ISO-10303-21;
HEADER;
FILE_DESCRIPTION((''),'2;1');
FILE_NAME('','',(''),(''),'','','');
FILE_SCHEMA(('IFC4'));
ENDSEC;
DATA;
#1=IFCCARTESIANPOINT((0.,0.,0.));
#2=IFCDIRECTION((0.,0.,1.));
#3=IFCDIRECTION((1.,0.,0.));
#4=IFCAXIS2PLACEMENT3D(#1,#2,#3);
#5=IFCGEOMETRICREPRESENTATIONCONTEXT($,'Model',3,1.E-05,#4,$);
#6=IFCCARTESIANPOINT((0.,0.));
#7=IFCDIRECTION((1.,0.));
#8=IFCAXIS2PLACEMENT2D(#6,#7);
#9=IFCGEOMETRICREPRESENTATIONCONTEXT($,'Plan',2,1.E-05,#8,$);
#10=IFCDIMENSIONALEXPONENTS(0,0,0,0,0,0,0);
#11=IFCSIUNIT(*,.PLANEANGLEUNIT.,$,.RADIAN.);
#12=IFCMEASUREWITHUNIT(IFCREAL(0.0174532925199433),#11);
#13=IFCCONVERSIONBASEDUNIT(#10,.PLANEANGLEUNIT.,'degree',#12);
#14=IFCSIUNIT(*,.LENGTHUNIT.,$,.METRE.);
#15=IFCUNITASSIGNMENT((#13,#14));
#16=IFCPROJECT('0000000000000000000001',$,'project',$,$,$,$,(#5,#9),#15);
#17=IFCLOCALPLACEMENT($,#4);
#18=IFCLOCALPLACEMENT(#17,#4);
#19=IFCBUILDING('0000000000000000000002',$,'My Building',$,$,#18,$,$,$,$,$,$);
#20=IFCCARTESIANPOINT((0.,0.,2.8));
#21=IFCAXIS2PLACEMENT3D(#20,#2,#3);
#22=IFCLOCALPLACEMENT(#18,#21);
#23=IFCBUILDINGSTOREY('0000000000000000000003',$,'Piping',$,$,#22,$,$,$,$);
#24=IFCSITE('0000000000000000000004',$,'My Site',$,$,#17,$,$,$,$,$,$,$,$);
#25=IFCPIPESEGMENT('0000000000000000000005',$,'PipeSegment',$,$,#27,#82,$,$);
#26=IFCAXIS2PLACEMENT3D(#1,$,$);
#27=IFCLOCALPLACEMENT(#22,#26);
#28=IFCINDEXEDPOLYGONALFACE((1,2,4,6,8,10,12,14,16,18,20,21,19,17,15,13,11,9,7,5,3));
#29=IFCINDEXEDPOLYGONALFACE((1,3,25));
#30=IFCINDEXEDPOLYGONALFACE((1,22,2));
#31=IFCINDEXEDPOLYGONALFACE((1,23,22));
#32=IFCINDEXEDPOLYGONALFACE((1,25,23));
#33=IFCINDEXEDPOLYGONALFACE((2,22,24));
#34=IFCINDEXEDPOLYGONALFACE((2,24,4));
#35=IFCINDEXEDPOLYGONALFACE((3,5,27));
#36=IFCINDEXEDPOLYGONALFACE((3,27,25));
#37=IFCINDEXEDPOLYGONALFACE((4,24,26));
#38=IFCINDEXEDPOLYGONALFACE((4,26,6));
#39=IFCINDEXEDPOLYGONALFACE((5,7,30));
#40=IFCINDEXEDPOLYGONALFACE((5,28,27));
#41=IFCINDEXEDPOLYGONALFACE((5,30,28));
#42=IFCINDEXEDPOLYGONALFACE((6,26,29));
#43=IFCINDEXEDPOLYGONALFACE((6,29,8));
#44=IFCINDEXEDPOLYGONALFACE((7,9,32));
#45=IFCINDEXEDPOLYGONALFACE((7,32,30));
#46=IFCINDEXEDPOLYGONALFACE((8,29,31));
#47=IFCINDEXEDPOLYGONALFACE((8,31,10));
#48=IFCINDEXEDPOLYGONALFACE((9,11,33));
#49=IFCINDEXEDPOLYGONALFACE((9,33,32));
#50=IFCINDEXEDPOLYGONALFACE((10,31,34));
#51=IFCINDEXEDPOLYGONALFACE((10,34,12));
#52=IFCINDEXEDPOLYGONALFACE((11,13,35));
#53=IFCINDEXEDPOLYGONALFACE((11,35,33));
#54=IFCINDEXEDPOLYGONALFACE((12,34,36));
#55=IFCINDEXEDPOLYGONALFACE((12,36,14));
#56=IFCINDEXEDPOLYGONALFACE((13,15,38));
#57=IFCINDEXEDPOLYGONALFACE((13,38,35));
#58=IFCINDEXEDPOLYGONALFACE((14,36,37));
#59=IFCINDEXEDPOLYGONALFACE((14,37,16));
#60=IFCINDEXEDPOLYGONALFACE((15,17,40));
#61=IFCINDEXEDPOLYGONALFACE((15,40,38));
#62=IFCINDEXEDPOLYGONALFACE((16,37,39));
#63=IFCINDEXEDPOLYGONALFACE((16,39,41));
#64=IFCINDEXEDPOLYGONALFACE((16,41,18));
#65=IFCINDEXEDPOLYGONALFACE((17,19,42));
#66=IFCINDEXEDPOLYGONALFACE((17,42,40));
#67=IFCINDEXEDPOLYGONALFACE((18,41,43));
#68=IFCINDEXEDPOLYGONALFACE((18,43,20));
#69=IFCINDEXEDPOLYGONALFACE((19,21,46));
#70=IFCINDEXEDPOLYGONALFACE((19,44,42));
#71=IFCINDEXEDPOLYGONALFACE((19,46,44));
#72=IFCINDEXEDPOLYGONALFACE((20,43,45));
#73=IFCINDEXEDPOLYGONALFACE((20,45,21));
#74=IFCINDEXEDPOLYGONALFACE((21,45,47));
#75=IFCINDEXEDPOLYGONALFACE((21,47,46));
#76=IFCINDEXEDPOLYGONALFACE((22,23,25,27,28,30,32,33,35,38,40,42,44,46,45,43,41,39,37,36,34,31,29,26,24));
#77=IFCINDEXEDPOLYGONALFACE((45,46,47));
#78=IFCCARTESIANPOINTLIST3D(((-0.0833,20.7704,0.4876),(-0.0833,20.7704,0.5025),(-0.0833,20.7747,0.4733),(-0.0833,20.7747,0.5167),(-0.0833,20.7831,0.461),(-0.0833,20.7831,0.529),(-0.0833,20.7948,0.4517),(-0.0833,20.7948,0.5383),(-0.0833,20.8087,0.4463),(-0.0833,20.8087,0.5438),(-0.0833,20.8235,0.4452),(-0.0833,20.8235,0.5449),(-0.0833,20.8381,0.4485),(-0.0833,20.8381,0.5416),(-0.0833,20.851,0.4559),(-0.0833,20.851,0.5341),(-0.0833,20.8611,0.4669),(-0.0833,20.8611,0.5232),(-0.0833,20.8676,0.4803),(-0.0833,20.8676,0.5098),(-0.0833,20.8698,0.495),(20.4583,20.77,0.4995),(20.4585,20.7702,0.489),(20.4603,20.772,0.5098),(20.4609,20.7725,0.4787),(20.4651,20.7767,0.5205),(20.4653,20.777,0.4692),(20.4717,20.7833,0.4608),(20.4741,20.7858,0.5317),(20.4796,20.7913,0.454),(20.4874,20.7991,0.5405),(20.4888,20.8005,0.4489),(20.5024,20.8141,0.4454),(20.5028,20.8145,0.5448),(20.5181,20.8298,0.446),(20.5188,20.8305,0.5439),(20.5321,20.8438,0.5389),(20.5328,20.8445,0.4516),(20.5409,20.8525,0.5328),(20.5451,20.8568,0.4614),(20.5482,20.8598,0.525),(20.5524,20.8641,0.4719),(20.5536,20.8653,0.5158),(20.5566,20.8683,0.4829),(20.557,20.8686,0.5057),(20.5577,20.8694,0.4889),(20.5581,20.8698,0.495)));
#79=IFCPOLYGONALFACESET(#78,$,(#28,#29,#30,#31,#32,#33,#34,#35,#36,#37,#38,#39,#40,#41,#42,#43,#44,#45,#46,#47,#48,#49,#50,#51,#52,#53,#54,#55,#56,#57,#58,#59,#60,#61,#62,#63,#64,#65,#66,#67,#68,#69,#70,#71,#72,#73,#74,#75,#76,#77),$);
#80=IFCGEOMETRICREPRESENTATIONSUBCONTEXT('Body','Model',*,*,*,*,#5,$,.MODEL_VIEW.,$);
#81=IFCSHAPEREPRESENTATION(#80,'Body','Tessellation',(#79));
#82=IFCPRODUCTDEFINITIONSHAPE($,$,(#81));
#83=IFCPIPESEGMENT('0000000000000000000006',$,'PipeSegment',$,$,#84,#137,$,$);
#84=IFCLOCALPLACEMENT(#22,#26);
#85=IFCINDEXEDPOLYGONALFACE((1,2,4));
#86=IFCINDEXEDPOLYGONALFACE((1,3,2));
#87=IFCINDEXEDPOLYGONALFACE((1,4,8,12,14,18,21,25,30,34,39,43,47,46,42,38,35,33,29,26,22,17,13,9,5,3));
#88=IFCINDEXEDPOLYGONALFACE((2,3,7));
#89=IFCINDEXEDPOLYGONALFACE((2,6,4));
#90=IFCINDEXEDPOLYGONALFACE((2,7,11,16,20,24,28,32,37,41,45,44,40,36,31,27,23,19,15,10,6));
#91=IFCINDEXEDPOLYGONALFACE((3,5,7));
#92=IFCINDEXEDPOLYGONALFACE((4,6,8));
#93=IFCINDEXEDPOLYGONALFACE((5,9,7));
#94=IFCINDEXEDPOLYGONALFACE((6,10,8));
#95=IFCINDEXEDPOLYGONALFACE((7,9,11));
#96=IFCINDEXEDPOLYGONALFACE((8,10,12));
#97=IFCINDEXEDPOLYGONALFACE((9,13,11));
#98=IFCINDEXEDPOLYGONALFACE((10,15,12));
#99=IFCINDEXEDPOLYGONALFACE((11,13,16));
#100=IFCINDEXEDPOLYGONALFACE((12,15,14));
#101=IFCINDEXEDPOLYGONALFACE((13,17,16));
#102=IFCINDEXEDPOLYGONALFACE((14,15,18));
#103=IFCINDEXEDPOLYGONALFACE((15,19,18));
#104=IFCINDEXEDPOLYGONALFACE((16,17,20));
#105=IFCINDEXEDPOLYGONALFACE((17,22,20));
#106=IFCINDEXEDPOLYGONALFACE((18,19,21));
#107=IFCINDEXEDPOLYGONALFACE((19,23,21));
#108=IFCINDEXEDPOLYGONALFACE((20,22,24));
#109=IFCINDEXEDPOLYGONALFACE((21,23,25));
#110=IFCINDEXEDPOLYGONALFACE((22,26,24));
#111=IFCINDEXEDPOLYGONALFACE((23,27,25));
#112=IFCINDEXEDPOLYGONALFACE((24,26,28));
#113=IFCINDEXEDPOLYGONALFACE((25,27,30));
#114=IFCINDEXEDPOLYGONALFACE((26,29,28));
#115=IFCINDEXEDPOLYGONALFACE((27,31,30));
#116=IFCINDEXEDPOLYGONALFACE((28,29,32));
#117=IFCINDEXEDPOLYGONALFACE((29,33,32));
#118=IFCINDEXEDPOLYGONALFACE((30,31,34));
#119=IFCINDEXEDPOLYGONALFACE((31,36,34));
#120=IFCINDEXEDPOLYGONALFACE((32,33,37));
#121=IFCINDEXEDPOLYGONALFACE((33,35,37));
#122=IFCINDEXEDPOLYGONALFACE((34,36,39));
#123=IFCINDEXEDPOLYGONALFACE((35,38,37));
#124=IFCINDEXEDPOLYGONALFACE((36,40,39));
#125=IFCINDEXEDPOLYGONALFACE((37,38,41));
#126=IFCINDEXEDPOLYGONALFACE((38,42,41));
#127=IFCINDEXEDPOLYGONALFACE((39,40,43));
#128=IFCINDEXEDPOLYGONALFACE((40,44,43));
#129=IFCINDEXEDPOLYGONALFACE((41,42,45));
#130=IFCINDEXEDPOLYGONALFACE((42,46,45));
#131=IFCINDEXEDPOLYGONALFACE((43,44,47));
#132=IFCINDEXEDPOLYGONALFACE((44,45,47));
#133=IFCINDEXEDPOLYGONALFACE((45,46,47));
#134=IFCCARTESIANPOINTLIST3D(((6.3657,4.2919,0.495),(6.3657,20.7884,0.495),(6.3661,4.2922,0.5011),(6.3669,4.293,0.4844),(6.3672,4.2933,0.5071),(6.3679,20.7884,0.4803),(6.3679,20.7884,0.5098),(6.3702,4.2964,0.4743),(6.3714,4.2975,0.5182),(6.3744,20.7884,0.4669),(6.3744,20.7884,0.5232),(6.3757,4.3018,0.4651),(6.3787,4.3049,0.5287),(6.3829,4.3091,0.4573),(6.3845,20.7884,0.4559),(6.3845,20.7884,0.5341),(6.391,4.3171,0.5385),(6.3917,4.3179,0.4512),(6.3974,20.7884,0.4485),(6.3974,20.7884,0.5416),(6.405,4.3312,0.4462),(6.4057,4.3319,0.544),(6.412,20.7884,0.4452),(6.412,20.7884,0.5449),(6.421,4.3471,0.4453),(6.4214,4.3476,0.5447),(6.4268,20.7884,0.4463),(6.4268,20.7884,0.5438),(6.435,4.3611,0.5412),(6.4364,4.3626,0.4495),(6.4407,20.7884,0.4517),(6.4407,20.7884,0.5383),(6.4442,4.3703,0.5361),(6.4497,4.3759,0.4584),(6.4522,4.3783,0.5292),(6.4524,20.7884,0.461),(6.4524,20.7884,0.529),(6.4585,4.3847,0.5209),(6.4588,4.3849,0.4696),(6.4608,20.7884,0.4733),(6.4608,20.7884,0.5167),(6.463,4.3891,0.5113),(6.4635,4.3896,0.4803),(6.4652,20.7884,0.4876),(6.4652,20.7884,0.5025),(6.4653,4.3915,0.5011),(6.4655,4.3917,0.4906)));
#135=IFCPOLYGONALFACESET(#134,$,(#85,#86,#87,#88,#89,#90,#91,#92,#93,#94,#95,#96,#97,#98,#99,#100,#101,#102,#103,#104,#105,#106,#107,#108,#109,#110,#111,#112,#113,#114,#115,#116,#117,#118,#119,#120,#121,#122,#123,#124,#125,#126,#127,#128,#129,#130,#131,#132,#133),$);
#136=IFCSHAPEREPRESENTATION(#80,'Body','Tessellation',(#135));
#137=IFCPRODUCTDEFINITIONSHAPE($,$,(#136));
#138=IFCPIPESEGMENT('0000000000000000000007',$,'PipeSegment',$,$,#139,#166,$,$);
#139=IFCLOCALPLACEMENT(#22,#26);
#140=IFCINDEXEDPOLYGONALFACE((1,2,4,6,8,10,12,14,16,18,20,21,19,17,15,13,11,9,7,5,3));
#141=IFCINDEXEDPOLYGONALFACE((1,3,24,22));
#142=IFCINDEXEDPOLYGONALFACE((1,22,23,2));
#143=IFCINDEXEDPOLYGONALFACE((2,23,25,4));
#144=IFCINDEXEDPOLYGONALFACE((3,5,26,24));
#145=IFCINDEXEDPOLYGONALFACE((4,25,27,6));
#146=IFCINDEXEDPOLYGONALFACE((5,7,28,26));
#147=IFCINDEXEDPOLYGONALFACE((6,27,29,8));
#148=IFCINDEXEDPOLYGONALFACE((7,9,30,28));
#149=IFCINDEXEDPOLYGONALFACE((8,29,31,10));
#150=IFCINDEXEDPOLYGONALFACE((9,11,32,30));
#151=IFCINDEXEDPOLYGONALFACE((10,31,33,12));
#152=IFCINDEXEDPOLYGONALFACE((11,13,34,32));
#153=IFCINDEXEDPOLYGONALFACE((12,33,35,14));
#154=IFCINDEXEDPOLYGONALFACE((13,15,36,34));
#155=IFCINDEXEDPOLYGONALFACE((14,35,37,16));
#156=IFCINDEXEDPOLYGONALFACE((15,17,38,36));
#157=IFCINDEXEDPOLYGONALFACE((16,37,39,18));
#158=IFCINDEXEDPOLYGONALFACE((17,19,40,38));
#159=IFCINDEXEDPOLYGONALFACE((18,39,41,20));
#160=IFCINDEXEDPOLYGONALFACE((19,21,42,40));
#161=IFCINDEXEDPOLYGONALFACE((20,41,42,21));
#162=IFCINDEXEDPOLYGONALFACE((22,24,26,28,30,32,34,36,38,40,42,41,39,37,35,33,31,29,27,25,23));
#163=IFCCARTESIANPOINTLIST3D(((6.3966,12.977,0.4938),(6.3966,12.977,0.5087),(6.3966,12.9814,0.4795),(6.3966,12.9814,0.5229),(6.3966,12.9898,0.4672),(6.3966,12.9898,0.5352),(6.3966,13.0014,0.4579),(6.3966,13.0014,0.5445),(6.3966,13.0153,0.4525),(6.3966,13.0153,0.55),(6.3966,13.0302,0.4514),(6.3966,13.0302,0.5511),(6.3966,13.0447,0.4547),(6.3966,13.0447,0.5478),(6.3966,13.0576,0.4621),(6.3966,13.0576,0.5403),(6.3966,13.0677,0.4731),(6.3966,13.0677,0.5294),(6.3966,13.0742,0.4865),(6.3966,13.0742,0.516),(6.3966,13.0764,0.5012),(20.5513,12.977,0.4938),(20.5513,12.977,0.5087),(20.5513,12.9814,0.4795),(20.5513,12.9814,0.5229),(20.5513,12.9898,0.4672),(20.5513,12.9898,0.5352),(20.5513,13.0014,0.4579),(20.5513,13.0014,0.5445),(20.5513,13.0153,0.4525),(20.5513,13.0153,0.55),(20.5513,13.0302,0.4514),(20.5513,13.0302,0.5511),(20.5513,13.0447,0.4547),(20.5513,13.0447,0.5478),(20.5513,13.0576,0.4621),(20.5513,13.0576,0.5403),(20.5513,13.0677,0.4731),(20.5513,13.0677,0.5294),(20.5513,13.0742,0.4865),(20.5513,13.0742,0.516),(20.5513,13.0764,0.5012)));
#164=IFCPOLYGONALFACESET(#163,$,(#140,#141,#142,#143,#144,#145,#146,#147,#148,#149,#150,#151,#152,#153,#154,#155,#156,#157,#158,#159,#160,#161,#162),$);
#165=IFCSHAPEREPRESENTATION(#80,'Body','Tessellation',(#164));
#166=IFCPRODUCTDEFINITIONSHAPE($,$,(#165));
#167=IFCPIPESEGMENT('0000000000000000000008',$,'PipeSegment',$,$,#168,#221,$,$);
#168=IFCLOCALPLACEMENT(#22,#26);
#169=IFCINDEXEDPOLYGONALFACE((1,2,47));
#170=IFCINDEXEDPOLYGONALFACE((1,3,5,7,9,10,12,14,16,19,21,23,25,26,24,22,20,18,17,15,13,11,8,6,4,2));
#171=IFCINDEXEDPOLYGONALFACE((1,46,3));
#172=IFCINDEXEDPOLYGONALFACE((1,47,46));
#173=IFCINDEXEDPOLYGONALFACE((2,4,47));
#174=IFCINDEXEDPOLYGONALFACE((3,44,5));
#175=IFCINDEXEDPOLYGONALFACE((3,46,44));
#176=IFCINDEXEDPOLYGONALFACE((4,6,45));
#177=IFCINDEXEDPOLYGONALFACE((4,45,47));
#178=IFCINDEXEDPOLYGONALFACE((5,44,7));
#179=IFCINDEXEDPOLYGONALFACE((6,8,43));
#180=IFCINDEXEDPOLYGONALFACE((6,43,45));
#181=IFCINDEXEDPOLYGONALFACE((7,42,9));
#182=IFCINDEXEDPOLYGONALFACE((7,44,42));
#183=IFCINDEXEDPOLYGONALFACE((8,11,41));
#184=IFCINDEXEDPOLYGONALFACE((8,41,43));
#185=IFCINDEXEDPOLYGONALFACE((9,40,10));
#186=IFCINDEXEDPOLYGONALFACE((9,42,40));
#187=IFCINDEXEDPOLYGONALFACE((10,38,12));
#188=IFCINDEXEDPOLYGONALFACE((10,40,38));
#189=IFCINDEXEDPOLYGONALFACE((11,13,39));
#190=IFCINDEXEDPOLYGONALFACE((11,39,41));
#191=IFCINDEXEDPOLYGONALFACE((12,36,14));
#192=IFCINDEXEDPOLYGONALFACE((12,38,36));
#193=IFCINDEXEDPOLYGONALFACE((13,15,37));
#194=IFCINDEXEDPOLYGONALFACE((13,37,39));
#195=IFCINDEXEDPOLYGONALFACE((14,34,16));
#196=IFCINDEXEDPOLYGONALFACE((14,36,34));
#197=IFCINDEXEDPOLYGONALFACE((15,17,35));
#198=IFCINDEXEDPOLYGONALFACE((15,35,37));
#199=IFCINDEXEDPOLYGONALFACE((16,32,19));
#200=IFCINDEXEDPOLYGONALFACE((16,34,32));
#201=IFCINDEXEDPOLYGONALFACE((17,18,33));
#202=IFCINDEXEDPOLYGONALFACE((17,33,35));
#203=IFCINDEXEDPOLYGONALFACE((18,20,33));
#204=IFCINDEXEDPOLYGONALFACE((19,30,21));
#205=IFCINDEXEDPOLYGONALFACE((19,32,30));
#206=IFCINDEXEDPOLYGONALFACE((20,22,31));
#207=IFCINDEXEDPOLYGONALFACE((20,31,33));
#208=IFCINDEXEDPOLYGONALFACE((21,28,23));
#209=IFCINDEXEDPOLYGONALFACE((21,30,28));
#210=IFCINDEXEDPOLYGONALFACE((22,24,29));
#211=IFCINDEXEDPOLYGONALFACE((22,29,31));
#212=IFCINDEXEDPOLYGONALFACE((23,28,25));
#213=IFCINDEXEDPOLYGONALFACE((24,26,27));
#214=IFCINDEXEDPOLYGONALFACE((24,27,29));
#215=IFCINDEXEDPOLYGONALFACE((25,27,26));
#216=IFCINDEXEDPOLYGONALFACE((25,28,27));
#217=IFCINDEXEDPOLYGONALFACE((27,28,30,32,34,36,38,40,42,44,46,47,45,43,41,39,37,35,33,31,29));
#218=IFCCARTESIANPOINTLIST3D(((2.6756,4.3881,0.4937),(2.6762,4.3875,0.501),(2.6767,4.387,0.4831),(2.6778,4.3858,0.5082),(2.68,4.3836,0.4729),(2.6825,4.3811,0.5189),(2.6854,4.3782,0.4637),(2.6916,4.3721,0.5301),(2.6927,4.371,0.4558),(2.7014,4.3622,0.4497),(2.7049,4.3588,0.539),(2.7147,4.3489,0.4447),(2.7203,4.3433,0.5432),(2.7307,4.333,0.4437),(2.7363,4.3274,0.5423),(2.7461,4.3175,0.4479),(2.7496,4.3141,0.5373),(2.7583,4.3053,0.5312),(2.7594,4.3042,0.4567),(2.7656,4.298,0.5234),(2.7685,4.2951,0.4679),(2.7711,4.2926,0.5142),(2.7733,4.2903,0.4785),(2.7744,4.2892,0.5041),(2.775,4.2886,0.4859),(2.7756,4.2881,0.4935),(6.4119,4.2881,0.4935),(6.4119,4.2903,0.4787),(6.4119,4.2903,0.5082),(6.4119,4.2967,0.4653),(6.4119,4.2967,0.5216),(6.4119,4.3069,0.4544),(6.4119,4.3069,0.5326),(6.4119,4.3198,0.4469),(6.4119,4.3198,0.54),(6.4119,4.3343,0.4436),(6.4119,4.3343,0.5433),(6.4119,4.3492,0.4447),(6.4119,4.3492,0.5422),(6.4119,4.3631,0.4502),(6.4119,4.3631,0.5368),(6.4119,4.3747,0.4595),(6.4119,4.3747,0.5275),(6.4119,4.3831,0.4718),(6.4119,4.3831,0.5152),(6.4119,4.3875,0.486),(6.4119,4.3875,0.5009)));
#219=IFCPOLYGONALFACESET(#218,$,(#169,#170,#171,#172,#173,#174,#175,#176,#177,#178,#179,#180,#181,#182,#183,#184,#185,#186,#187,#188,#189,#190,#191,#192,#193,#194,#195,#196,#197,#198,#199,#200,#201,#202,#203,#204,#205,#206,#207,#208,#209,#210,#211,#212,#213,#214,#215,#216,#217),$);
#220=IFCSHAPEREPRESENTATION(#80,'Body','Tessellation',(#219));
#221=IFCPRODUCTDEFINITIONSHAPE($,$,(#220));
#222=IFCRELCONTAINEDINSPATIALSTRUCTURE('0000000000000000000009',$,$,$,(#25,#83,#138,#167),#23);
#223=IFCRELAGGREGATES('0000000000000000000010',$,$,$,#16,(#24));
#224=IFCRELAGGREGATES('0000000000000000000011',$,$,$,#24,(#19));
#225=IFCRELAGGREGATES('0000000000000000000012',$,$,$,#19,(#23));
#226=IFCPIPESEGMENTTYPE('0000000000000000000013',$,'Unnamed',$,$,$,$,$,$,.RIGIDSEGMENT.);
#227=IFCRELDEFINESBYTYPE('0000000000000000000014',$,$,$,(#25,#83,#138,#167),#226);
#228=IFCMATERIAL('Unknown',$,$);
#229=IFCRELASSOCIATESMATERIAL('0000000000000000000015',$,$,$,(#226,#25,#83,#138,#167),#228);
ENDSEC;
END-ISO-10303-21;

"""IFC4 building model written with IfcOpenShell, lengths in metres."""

from ifc_helpers import new_model, entity, si_unit, converted_unit, frame, origin_with_axes, origin_2d_with_axis, place, context, subcontext, project, spatial, circle, extrude, clip, halfspace, material, material_profile, profile_set, profile_usage, type_object, element, save


model = new_model("IFC4")

# Units and contexts
model_context = context("Model", 3, precision=1e-05, world=origin_with_axes())
plan_context = context("Plan", 2, precision=1e-05, world=origin_2d_with_axis())
body_context = subcontext(model_context, "Body", "Model", "MODEL_VIEW")
ifc_project = project(units=[converted_unit("PLANEANGLEUNIT", "degree", entity("IfcReal", 0.0174532925199433), si_unit("PLANEANGLEUNIT", "RADIAN"), dimensions=[0, 0, 0, 0, 0, 0, 0]), si_unit("LENGTHUNIT", "METRE")], contexts=[model_context, plan_context])

# Site, building, storey
site_placement = place(None, origin_with_axes())
site = spatial("IfcSite", under=ifc_project, at=site_placement, Name="My Site")
building_placement = place(site_placement, origin_with_axes())
building = spatial("IfcBuilding", under=site, at=building_placement, Name="My Building")
storey_placement = place(building_placement, frame((0.0, 0.0, 2.8), z_axis=(0.0, 0.0, 1.0), x_axis=(1.0, 0.0, 0.0)))
storey = spatial("IfcBuildingStorey", under=building, at=storey_placement, Name="Piping")

# Pipe segments
ifc_material = material(Name="Unknown")
ifc_material_profile_1 = material_profile(ifc_material, circle(Radius=0.05))
ifc_profile_set_1 = profile_set([ifc_material_profile_1])
ifc_profile_usage_1 = profile_usage(ifc_profile_set_1, cardinal=5)
pipe_segment_type = type_object("IfcPipeSegmentType", Name="Unnamed", PredefinedType="RIGIDSEGMENT", material=ifc_profile_set_1)
pipe_segment_1_placement = place(storey_placement, frame((-0.0833, 20.8198, 0.495), z_axis=(1.0, -0.000001, 0.000001), x_axis=(0.000001, 1.0, 0.0)))
element("IfcPipeSegment", 1, at=pipe_segment_1_placement, inside=storey, type_object=pipe_segment_type, material=ifc_profile_usage_1, Name="PipeSegment", context=body_context, shape_type="Clipping", body=[
    clip(extrude(circle(Radius=0.05), origin_with_axes(), (0.0, 0.0, 1.0), 20.6414), halfspace(frame((0.05, 0.0, 20.6414), z_axis=(-0.707107, -0.000001, 0.707107), x_axis=(-0.000001, 1.0, 0.0)), False)),
])
ifc_profile_usage_2 = profile_usage(ifc_profile_set_1, cardinal=5)
pipe_segment_2_placement = place(storey_placement, frame((6.4157, 4.2919, 0.495), z_axis=(0.0, 1.0, 0.0), x_axis=(-1.0, 0.0, 0.0)))
element("IfcPipeSegment", 2, at=pipe_segment_2_placement, inside=storey, type_object=pipe_segment_type, material=ifc_profile_usage_2, Name="PipeSegment", context=body_context, shape_type="Clipping", body=[
    clip(extrude(circle(Radius=0.05), origin_with_axes(), (0.0, 0.0, 1.0), 16.4965), halfspace(frame((0.05, 0.0, 0.0), z_axis=(-0.707107, 0.0, -0.707107), x_axis=(0.0, 1.0, 0.0)), False)),
])
ifc_profile_usage_3 = profile_usage(ifc_profile_set_1, cardinal=5)
pipe_segment_3_placement = place(storey_placement, frame((6.3966, 13.0264, 0.5012), z_axis=(1.0, 0.0, 0.0), x_axis=(0.0, 1.0, 0.0)))
element("IfcPipeSegment", 3, at=pipe_segment_3_placement, inside=storey, type_object=pipe_segment_type, material=ifc_profile_usage_3, Name="PipeSegment", context=body_context, shape_type="SweptSolid", body=[
    extrude(circle(Radius=0.05), origin_with_axes(), (0.0, 0.0, 1.0), 14.1547),
])
ifc_profile_usage_4 = profile_usage(ifc_profile_set_1, cardinal=5)
pipe_segment_4_placement = place(storey_placement, frame((6.4119, 4.3381, 0.4935), z_axis=(-1.0, 0.0, 0.0), x_axis=(0.0, -1.0, 0.0)))
element("IfcPipeSegment", 4, at=pipe_segment_4_placement, inside=storey, type_object=pipe_segment_type, material=ifc_profile_usage_4, Name="PipeSegment", context=body_context, shape_type="Clipping", body=[
    clip(extrude(circle(Radius=0.05), origin_with_axes(), (0.0, 0.0, 1.0), 3.7363), halfspace(frame((-0.05, -0.0499, 3.7363), z_axis=(0.707105, 0.0, 0.707109), x_axis=(0.0, -1.0, 0.0)), False)),
])

save(model, "model.ifc")
